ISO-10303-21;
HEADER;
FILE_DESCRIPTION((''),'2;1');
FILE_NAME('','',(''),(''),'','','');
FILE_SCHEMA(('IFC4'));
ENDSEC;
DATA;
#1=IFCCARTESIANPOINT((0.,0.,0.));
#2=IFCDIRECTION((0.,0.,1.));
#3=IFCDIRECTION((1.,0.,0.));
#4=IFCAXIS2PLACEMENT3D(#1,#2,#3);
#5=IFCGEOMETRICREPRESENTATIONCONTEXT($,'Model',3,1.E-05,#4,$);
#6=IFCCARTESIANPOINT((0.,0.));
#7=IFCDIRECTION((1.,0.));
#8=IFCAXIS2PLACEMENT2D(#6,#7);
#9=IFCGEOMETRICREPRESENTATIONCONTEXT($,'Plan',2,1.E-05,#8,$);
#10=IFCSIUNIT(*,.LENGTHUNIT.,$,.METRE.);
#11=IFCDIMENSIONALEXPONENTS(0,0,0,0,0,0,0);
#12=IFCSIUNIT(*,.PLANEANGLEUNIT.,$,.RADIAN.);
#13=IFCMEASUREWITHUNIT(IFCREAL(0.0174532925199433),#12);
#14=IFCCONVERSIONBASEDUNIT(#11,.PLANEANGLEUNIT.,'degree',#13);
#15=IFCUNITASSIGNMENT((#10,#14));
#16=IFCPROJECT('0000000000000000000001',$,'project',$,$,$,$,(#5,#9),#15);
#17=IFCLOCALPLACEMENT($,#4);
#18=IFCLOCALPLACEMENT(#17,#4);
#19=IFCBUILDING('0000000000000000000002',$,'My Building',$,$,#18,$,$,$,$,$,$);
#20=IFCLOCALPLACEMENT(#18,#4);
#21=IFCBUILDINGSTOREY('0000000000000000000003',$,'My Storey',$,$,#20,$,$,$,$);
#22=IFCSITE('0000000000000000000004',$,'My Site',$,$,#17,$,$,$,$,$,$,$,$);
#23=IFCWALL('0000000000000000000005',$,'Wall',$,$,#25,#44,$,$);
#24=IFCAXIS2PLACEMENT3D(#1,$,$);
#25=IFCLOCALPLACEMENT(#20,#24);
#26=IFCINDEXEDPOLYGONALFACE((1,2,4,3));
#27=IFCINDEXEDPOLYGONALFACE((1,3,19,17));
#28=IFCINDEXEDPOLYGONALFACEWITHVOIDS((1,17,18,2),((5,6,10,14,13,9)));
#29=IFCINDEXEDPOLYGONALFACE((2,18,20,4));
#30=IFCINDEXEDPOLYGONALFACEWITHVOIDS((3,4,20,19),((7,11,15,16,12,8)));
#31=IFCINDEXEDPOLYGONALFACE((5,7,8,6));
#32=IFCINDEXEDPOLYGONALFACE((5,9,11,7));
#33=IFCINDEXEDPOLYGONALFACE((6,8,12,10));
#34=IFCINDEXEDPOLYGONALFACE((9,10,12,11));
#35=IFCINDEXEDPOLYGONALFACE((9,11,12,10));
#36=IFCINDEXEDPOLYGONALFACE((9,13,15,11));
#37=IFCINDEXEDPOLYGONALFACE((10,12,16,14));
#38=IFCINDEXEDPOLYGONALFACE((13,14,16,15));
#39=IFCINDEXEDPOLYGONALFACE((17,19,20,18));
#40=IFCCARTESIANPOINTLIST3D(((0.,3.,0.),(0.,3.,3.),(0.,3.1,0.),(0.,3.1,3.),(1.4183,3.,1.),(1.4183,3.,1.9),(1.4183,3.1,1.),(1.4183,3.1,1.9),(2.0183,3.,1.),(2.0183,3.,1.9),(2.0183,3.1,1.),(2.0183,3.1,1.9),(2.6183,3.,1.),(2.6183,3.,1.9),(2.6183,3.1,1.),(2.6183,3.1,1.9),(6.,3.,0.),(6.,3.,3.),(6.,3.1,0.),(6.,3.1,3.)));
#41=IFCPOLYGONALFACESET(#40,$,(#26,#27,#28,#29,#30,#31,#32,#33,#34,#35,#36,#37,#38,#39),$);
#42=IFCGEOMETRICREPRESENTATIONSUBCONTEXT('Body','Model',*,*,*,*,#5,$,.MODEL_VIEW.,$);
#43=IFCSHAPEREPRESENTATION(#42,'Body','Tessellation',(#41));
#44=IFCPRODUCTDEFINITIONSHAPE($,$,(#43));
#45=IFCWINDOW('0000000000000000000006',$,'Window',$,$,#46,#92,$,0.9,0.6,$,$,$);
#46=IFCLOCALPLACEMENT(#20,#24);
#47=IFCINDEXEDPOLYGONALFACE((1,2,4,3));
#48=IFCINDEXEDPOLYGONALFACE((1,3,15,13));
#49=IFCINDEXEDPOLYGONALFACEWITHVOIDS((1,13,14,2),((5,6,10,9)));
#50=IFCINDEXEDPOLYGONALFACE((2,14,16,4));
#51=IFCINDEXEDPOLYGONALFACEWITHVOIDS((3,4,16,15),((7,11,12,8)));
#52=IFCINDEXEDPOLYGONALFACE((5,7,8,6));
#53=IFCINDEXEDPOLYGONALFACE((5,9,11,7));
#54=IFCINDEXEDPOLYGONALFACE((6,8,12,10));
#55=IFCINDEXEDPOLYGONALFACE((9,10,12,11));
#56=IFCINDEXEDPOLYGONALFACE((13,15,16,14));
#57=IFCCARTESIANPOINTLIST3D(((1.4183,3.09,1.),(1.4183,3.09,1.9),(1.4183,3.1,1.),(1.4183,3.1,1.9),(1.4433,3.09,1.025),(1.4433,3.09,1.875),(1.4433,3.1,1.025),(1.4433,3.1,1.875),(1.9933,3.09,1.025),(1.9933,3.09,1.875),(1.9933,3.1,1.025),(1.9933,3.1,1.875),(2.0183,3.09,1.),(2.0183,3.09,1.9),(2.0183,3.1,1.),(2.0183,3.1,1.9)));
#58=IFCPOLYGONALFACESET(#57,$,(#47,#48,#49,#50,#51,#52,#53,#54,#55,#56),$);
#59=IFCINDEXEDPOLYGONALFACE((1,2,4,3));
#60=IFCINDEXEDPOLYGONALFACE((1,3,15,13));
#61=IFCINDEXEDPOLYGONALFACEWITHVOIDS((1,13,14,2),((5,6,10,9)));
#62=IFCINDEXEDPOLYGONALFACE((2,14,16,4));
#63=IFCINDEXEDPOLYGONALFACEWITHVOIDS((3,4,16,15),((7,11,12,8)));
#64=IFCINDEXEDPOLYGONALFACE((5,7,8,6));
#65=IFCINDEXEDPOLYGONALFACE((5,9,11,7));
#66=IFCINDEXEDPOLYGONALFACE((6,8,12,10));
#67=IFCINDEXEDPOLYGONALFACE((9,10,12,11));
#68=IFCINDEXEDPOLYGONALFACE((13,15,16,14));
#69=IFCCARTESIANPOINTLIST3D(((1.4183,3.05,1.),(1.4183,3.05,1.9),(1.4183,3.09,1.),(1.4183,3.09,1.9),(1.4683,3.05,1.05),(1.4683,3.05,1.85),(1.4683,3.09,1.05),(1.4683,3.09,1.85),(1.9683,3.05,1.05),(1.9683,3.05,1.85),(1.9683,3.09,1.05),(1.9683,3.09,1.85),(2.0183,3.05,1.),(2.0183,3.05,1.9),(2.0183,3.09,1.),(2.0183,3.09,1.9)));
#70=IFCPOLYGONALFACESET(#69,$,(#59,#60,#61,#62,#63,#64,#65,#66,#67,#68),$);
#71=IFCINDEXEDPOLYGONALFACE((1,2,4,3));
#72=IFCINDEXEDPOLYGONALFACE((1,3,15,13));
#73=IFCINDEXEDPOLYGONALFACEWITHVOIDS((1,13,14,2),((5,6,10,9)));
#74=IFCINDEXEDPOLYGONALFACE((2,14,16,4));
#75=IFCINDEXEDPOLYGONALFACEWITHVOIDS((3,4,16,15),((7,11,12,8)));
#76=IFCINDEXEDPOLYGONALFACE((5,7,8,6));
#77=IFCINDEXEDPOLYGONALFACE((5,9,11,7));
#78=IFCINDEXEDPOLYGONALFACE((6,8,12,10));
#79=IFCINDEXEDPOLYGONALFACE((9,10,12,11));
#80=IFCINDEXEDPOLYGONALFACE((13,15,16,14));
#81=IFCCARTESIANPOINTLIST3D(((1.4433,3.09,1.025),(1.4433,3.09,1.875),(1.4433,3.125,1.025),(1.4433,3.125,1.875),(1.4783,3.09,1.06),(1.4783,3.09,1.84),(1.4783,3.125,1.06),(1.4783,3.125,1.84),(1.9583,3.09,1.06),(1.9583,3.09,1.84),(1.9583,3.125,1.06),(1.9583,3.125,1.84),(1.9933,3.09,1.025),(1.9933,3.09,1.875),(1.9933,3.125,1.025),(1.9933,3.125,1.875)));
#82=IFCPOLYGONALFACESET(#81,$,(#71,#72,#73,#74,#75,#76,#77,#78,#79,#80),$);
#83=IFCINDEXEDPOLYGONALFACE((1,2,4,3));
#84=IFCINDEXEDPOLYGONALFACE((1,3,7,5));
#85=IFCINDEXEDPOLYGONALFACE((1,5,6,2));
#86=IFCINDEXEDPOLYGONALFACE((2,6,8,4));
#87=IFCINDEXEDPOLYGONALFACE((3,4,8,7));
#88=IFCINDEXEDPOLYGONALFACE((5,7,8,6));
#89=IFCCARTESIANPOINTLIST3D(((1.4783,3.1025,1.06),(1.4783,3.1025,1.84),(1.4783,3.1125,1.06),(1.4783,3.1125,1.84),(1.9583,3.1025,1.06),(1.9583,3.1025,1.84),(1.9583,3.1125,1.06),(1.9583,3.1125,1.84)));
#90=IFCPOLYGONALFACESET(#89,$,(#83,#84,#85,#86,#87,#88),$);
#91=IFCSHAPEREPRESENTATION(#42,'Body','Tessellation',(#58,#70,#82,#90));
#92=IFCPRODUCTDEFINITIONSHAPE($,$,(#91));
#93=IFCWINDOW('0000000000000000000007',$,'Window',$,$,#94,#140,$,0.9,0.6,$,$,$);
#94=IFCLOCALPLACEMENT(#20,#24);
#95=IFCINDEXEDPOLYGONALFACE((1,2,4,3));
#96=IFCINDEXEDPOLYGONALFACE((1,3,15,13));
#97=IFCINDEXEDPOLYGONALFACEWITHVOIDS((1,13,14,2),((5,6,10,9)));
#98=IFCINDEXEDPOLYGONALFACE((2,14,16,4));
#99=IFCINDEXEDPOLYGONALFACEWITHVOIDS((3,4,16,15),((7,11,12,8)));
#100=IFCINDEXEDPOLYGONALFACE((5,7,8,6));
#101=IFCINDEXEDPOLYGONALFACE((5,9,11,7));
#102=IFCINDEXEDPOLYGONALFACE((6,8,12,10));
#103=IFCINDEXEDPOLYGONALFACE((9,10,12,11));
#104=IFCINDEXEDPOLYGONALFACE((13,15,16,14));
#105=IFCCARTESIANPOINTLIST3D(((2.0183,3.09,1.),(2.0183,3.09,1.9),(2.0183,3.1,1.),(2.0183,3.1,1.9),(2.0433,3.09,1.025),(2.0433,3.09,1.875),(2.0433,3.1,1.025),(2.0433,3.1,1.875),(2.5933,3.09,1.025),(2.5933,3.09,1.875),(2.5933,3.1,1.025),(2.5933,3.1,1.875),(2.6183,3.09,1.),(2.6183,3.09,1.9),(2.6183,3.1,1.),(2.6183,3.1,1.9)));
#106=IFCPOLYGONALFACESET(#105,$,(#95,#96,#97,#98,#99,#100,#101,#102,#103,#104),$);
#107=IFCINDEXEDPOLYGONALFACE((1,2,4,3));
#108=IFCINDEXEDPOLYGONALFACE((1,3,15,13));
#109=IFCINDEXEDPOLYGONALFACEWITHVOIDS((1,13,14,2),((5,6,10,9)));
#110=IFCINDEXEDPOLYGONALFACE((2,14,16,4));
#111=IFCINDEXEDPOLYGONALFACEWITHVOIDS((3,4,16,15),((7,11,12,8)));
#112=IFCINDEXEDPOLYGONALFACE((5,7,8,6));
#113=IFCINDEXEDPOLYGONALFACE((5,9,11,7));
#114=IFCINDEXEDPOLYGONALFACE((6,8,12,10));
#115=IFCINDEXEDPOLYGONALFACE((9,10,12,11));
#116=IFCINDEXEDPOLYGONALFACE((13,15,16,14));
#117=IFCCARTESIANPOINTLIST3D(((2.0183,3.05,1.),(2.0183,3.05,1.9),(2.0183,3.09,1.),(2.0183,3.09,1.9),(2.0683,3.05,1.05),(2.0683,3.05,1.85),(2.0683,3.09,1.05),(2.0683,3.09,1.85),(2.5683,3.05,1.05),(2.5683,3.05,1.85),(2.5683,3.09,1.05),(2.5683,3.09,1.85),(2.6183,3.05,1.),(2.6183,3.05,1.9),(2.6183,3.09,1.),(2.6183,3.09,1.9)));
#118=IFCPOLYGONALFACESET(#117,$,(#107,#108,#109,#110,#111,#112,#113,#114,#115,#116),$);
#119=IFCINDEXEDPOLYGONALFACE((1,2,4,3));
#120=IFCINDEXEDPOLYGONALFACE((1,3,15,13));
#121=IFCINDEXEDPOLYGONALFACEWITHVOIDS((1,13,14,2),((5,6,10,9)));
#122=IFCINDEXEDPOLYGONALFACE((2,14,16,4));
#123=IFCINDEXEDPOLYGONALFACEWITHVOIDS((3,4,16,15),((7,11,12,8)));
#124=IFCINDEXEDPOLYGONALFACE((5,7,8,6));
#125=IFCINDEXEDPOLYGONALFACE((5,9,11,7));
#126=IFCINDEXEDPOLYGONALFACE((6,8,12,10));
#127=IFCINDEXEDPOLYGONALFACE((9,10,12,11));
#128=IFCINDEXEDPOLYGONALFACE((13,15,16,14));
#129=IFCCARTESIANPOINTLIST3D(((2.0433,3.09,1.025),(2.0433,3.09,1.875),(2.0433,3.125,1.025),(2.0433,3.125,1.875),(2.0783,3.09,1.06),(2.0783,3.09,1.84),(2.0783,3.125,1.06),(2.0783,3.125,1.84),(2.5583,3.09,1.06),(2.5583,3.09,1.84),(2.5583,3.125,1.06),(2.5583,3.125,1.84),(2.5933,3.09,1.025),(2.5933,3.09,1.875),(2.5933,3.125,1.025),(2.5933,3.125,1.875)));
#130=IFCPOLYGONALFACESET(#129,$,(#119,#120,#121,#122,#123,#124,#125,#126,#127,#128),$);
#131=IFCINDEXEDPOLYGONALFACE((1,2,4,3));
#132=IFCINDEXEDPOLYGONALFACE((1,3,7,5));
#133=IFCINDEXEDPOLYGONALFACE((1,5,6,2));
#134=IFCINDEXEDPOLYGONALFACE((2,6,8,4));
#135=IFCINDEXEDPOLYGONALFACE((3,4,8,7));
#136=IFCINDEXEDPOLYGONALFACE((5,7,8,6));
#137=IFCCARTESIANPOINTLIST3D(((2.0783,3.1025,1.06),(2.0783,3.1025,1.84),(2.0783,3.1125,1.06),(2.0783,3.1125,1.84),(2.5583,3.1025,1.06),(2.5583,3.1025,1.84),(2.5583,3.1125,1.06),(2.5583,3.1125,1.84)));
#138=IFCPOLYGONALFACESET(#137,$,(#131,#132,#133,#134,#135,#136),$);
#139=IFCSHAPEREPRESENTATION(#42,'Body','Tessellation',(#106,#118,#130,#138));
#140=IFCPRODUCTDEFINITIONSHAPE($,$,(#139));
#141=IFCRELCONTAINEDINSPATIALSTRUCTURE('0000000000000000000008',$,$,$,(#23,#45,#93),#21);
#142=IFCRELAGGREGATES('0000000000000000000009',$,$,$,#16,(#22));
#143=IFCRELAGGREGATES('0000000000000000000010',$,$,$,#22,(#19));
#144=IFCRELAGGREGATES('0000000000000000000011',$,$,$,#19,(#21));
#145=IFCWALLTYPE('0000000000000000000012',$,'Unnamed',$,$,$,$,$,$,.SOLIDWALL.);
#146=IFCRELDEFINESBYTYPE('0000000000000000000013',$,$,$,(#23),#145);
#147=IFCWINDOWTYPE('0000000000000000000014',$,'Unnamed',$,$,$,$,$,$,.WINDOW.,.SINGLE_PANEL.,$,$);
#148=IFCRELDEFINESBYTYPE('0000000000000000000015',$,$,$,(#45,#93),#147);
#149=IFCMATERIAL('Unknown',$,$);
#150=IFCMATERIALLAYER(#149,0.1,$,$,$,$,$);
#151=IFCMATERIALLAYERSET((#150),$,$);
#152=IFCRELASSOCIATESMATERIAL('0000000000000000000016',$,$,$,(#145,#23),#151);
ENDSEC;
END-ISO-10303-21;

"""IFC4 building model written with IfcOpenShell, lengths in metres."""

from ifc_helpers import new_model, entity, si_unit, converted_unit, frame, origin_with_axes, origin_2d_with_axis, place, context, subcontext, project, spatial, line, indexed_curve, outline, extrude, shape, source, transform, mapped, material, layer, layer_set, layer_usage, type_object, type_shapes, element, fill, save


model = new_model("IFC4")

# Units and contexts
model_context = context("Model", 3, precision=1e-05, world=origin_with_axes())
plan_context = context("Plan", 2, precision=1e-05, world=origin_2d_with_axis())
body_context_1 = subcontext(model_context, "Body", "Model", "MODEL_VIEW")
body_context_2 = subcontext(plan_context, "Body", "Plan", "PLAN_VIEW")
ifc_project = project(units=[si_unit("LENGTHUNIT", "METRE"), converted_unit("PLANEANGLEUNIT", "degree", entity("IfcReal", 0.0174532925199433), si_unit("PLANEANGLEUNIT", "RADIAN"), dimensions=[0, 0, 0, 0, 0, 0, 0])], contexts=[model_context, plan_context])

# Site, building, storey
site_placement = place(None, origin_with_axes())
site = spatial("IfcSite", under=ifc_project, at=site_placement, Name="My Site")
building_placement = place(site_placement, origin_with_axes())
building = spatial("IfcBuilding", under=site, at=building_placement, Name="My Building")
storey_placement = place(building_placement, origin_with_axes())
storey = spatial("IfcBuildingStorey", under=building, at=storey_placement, Name="My Storey")

# Shared definitions
ifc_material = material(Name="Unknown")

# Shared definitions
ifc_layer_1 = layer(ifc_material, 0.1)
ifc_layer_set_1 = layer_set([ifc_layer_1])
wall_type = type_object("IfcWallType", Name="Unnamed", PredefinedType="SOLIDWALL", material=ifc_layer_set_1)
shared_shape_1 = source(origin_with_axes(), body_context_1, "Body", "SweptSolid", [
    extrude(outline(indexed_curve([(0.0, 0.0), (0.6, 0.0), (0.6, 0.9), (0.0, 0.9)], segments=[line(1, 2, 3, 4, 1)])), frame((0.0, -0.6, 0.0), z_axis=(0.0, -1.0, 0.0), x_axis=(1.0, 0.0, 0.0)), (0.0, 0.0, -1.0), 1.2),
])
window_type = type_object("IfcWindowType", Name="Unnamed", PartitioningType="SINGLE_PANEL", PredefinedType="WINDOW")
shared_shape_2 = source(origin_with_axes(), body_context_1, "Body", "SweptSolid", [
    extrude(outline(indexed_curve([(0.0, 0.0), (0.6, 0.0), (0.6, 0.9), (0.0, 0.9)], segments=[line(1, 2, 3, 4, 1)]), holes=[indexed_curve([(0.025, 0.025), (0.575, 0.025), (0.575, 0.875), (0.025, 0.875)], segments=[line(1, 2, 3, 4, 1)])]), frame((0.0, 0.09, 0.0), z_axis=(0.0, -1.0, 0.0), x_axis=(1.0, 0.0, 0.0)), (0.0, 0.0, -1.0), 0.01),
    extrude(outline(indexed_curve([(0.0, 0.0), (0.6, 0.0), (0.6, 0.9), (0.0, 0.9)], segments=[line(1, 2, 3, 4, 1)]), holes=[indexed_curve([(0.05, 0.05), (0.55, 0.05), (0.55, 0.85), (0.05, 0.85)], segments=[line(1, 2, 3, 4, 1)])]), frame((0.0, 0.05, 0.0), z_axis=(0.0, -1.0, 0.0), x_axis=(1.0, 0.0, 0.0)), (0.0, 0.0, -1.0), 0.04),
    extrude(outline(indexed_curve([(0.0, 0.0), (0.55, 0.0), (0.55, 0.85), (0.0, 0.85)], segments=[line(1, 2, 3, 4, 1)]), holes=[indexed_curve([(0.035, 0.035), (0.515, 0.035), (0.515, 0.815), (0.035, 0.815)], segments=[line(1, 2, 3, 4, 1)])]), frame((0.025, 0.09, 0.025), z_axis=(0.0, -1.0, 0.0), x_axis=(1.0, 0.0, 0.0)), (0.0, 0.0, -1.0), 0.035),
    extrude(outline(indexed_curve([(0.035, 0.035), (0.515, 0.035), (0.515, 0.815), (0.035, 0.815)], segments=[line(1, 2, 3, 4, 1)])), frame((0.025, 0.1025, 0.025), z_axis=(0.0, -1.0, 0.0), x_axis=(1.0, 0.0, 0.0)), (0.0, 0.0, -1.0), 0.01),
])
shared_shape_3 = source(origin_with_axes(), body_context_2, "Body", "Curve2D", [
    entity("IfcIndexedPolyCurve", entity("IfcCartesianPointList2D", [[0.05, 0.05], [0.55, 0.05]])),
    entity("IfcIndexedPolyCurve", entity("IfcCartesianPointList2D", [[0.0, 0.1], [0.025, 0.1], [0.025, 0.09], [0.05, 0.09], [0.05, 0.05], [0.0, 0.05]]), [entity("IfcLineIndex", [1, 2, 3, 4, 5, 6, 1])]),
    entity("IfcIndexedPolyCurve", entity("IfcCartesianPointList2D", [[0.6, 0.1], [0.575, 0.1], [0.575, 0.09], [0.55, 0.09], [0.55, 0.05], [0.6, 0.05]]), [entity("IfcLineIndex", [1, 2, 3, 4, 5, 6, 1])]),
    entity("IfcIndexedPolyCurve", entity("IfcCartesianPointList2D", [[0.025, 0.09], [0.06, 0.09], [0.06, 0.125], [0.025, 0.125]]), [entity("IfcLineIndex", [1, 2, 3, 4, 1])]),
    entity("IfcIndexedPolyCurve", entity("IfcCartesianPointList2D", [[0.575, 0.09], [0.54, 0.09], [0.54, 0.125], [0.575, 0.125]]), [entity("IfcLineIndex", [1, 2, 3, 4, 1])]),
    entity("IfcIndexedPolyCurve", entity("IfcCartesianPointList2D", [[0.06, 0.09], [0.54, 0.09]])),
    entity("IfcIndexedPolyCurve", entity("IfcCartesianPointList2D", [[0.06, 0.125], [0.54, 0.125]])),
    entity("IfcIndexedPolyCurve", entity("IfcCartesianPointList2D", [[0.06, 0.1075], [0.54, 0.1075]])),
])
type_shapes(window_type, [shared_shape_2, shared_shape_3])

# Wall, openings, windows
ifc_layer_usage_1 = layer_usage(ifc_layer_set_1, "AXIS2", "POSITIVE", 0.0)
wall_1_placement = place(storey_placement, frame((0.0, 3.0, 0.0), z_axis=(0.0, 0.0, 1.0), x_axis=(1.0, 0.0, 0.0)))
wall_1 = element("IfcWall", 1, at=wall_1_placement, inside=storey, type_object=wall_type, material=ifc_layer_usage_1, Name="Wall", context=body_context_1, shape_type="SweptSolid", body=[
    extrude(outline(indexed_curve([(0.0, 0.0), (0.0, 0.1), (6.0, 0.1), (6.0, 0.0)], segments=[line(1, 2, 3, 4, 1)])), origin_with_axes(), (0.0, 0.0, 1.0), 3.0),
])
opening_1_placement = place(wall_1_placement, frame((1.4183, 0.0, 1.0), z_axis=(0.0, 0.0, 1.0), x_axis=(1.0, 0.0, 0.0)))
opening_1 = element("IfcOpeningElement", 2, at=opening_1_placement, cuts=wall_1, PredefinedType="OPENING", context=body_context_1, shape_type="MappedRepresentation", body=[
    mapped(shared_shape_1, transform((0.0, 0.0, 0.0), x_axis=(1.0, 0.0, 0.0), y_axis=(0.0, 1.0, 0.0), z_axis=(0.0, 0.0, 1.0), scale=1.0)),
])
opening_2_placement = place(wall_1_placement, frame((2.0183, 0.0, 1.0), z_axis=(0.0, 0.0, 1.0), x_axis=(1.0, 0.0, 0.0)))
opening_2 = element("IfcOpeningElement", 3, at=opening_2_placement, cuts=wall_1, PredefinedType="OPENING", context=body_context_1, shape_type="MappedRepresentation", body=[
    mapped(shared_shape_1, transform((0.0, 0.0, 0.0), x_axis=(1.0, 0.0, 0.0), y_axis=(0.0, 1.0, 0.0), z_axis=(0.0, 0.0, 1.0), scale=1.0)),
])
window_1_placement = place(opening_1_placement, origin_with_axes())
window_1 = element("IfcWindow", 4, at=window_1_placement, inside=storey, type_object=window_type, Name="Window", OverallHeight=0.9, OverallWidth=0.6, shapes=[
    shape(body_context_1, "Body", "MappedRepresentation", [mapped(shared_shape_2, transform((0.0, 0.0, 0.0), x_axis=(1.0, 0.0, 0.0), y_axis=(0.0, 1.0, 0.0), z_axis=(0.0, 0.0, 1.0), scale=1.0))]),
    shape(body_context_2, "Body", "MappedRepresentation", [mapped(shared_shape_3, transform((0.0, 0.0, 0.0), x_axis=(1.0, 0.0, 0.0), y_axis=(0.0, 1.0, 0.0), z_axis=(0.0, 0.0, 1.0), scale=1.0))]),
])
fill(opening_1, window_1)
window_2_placement = place(opening_2_placement, origin_with_axes())
window_2 = element("IfcWindow", 5, at=window_2_placement, inside=storey, type_object=window_type, Name="Window", OverallHeight=0.9, OverallWidth=0.6, shapes=[
    shape(body_context_1, "Body", "MappedRepresentation", [mapped(shared_shape_2, transform((0.0, 0.0, 0.0), x_axis=(1.0, 0.0, 0.0), y_axis=(0.0, 1.0, 0.0), z_axis=(0.0, 0.0, 1.0), scale=1.0))]),
    shape(body_context_2, "Body", "MappedRepresentation", [mapped(shared_shape_3, transform((0.0, 0.0, 0.0), x_axis=(1.0, 0.0, 0.0), y_axis=(0.0, 1.0, 0.0), z_axis=(0.0, 0.0, 1.0), scale=1.0))]),
])
fill(opening_2, window_2)

save(model, "model.ifc")
